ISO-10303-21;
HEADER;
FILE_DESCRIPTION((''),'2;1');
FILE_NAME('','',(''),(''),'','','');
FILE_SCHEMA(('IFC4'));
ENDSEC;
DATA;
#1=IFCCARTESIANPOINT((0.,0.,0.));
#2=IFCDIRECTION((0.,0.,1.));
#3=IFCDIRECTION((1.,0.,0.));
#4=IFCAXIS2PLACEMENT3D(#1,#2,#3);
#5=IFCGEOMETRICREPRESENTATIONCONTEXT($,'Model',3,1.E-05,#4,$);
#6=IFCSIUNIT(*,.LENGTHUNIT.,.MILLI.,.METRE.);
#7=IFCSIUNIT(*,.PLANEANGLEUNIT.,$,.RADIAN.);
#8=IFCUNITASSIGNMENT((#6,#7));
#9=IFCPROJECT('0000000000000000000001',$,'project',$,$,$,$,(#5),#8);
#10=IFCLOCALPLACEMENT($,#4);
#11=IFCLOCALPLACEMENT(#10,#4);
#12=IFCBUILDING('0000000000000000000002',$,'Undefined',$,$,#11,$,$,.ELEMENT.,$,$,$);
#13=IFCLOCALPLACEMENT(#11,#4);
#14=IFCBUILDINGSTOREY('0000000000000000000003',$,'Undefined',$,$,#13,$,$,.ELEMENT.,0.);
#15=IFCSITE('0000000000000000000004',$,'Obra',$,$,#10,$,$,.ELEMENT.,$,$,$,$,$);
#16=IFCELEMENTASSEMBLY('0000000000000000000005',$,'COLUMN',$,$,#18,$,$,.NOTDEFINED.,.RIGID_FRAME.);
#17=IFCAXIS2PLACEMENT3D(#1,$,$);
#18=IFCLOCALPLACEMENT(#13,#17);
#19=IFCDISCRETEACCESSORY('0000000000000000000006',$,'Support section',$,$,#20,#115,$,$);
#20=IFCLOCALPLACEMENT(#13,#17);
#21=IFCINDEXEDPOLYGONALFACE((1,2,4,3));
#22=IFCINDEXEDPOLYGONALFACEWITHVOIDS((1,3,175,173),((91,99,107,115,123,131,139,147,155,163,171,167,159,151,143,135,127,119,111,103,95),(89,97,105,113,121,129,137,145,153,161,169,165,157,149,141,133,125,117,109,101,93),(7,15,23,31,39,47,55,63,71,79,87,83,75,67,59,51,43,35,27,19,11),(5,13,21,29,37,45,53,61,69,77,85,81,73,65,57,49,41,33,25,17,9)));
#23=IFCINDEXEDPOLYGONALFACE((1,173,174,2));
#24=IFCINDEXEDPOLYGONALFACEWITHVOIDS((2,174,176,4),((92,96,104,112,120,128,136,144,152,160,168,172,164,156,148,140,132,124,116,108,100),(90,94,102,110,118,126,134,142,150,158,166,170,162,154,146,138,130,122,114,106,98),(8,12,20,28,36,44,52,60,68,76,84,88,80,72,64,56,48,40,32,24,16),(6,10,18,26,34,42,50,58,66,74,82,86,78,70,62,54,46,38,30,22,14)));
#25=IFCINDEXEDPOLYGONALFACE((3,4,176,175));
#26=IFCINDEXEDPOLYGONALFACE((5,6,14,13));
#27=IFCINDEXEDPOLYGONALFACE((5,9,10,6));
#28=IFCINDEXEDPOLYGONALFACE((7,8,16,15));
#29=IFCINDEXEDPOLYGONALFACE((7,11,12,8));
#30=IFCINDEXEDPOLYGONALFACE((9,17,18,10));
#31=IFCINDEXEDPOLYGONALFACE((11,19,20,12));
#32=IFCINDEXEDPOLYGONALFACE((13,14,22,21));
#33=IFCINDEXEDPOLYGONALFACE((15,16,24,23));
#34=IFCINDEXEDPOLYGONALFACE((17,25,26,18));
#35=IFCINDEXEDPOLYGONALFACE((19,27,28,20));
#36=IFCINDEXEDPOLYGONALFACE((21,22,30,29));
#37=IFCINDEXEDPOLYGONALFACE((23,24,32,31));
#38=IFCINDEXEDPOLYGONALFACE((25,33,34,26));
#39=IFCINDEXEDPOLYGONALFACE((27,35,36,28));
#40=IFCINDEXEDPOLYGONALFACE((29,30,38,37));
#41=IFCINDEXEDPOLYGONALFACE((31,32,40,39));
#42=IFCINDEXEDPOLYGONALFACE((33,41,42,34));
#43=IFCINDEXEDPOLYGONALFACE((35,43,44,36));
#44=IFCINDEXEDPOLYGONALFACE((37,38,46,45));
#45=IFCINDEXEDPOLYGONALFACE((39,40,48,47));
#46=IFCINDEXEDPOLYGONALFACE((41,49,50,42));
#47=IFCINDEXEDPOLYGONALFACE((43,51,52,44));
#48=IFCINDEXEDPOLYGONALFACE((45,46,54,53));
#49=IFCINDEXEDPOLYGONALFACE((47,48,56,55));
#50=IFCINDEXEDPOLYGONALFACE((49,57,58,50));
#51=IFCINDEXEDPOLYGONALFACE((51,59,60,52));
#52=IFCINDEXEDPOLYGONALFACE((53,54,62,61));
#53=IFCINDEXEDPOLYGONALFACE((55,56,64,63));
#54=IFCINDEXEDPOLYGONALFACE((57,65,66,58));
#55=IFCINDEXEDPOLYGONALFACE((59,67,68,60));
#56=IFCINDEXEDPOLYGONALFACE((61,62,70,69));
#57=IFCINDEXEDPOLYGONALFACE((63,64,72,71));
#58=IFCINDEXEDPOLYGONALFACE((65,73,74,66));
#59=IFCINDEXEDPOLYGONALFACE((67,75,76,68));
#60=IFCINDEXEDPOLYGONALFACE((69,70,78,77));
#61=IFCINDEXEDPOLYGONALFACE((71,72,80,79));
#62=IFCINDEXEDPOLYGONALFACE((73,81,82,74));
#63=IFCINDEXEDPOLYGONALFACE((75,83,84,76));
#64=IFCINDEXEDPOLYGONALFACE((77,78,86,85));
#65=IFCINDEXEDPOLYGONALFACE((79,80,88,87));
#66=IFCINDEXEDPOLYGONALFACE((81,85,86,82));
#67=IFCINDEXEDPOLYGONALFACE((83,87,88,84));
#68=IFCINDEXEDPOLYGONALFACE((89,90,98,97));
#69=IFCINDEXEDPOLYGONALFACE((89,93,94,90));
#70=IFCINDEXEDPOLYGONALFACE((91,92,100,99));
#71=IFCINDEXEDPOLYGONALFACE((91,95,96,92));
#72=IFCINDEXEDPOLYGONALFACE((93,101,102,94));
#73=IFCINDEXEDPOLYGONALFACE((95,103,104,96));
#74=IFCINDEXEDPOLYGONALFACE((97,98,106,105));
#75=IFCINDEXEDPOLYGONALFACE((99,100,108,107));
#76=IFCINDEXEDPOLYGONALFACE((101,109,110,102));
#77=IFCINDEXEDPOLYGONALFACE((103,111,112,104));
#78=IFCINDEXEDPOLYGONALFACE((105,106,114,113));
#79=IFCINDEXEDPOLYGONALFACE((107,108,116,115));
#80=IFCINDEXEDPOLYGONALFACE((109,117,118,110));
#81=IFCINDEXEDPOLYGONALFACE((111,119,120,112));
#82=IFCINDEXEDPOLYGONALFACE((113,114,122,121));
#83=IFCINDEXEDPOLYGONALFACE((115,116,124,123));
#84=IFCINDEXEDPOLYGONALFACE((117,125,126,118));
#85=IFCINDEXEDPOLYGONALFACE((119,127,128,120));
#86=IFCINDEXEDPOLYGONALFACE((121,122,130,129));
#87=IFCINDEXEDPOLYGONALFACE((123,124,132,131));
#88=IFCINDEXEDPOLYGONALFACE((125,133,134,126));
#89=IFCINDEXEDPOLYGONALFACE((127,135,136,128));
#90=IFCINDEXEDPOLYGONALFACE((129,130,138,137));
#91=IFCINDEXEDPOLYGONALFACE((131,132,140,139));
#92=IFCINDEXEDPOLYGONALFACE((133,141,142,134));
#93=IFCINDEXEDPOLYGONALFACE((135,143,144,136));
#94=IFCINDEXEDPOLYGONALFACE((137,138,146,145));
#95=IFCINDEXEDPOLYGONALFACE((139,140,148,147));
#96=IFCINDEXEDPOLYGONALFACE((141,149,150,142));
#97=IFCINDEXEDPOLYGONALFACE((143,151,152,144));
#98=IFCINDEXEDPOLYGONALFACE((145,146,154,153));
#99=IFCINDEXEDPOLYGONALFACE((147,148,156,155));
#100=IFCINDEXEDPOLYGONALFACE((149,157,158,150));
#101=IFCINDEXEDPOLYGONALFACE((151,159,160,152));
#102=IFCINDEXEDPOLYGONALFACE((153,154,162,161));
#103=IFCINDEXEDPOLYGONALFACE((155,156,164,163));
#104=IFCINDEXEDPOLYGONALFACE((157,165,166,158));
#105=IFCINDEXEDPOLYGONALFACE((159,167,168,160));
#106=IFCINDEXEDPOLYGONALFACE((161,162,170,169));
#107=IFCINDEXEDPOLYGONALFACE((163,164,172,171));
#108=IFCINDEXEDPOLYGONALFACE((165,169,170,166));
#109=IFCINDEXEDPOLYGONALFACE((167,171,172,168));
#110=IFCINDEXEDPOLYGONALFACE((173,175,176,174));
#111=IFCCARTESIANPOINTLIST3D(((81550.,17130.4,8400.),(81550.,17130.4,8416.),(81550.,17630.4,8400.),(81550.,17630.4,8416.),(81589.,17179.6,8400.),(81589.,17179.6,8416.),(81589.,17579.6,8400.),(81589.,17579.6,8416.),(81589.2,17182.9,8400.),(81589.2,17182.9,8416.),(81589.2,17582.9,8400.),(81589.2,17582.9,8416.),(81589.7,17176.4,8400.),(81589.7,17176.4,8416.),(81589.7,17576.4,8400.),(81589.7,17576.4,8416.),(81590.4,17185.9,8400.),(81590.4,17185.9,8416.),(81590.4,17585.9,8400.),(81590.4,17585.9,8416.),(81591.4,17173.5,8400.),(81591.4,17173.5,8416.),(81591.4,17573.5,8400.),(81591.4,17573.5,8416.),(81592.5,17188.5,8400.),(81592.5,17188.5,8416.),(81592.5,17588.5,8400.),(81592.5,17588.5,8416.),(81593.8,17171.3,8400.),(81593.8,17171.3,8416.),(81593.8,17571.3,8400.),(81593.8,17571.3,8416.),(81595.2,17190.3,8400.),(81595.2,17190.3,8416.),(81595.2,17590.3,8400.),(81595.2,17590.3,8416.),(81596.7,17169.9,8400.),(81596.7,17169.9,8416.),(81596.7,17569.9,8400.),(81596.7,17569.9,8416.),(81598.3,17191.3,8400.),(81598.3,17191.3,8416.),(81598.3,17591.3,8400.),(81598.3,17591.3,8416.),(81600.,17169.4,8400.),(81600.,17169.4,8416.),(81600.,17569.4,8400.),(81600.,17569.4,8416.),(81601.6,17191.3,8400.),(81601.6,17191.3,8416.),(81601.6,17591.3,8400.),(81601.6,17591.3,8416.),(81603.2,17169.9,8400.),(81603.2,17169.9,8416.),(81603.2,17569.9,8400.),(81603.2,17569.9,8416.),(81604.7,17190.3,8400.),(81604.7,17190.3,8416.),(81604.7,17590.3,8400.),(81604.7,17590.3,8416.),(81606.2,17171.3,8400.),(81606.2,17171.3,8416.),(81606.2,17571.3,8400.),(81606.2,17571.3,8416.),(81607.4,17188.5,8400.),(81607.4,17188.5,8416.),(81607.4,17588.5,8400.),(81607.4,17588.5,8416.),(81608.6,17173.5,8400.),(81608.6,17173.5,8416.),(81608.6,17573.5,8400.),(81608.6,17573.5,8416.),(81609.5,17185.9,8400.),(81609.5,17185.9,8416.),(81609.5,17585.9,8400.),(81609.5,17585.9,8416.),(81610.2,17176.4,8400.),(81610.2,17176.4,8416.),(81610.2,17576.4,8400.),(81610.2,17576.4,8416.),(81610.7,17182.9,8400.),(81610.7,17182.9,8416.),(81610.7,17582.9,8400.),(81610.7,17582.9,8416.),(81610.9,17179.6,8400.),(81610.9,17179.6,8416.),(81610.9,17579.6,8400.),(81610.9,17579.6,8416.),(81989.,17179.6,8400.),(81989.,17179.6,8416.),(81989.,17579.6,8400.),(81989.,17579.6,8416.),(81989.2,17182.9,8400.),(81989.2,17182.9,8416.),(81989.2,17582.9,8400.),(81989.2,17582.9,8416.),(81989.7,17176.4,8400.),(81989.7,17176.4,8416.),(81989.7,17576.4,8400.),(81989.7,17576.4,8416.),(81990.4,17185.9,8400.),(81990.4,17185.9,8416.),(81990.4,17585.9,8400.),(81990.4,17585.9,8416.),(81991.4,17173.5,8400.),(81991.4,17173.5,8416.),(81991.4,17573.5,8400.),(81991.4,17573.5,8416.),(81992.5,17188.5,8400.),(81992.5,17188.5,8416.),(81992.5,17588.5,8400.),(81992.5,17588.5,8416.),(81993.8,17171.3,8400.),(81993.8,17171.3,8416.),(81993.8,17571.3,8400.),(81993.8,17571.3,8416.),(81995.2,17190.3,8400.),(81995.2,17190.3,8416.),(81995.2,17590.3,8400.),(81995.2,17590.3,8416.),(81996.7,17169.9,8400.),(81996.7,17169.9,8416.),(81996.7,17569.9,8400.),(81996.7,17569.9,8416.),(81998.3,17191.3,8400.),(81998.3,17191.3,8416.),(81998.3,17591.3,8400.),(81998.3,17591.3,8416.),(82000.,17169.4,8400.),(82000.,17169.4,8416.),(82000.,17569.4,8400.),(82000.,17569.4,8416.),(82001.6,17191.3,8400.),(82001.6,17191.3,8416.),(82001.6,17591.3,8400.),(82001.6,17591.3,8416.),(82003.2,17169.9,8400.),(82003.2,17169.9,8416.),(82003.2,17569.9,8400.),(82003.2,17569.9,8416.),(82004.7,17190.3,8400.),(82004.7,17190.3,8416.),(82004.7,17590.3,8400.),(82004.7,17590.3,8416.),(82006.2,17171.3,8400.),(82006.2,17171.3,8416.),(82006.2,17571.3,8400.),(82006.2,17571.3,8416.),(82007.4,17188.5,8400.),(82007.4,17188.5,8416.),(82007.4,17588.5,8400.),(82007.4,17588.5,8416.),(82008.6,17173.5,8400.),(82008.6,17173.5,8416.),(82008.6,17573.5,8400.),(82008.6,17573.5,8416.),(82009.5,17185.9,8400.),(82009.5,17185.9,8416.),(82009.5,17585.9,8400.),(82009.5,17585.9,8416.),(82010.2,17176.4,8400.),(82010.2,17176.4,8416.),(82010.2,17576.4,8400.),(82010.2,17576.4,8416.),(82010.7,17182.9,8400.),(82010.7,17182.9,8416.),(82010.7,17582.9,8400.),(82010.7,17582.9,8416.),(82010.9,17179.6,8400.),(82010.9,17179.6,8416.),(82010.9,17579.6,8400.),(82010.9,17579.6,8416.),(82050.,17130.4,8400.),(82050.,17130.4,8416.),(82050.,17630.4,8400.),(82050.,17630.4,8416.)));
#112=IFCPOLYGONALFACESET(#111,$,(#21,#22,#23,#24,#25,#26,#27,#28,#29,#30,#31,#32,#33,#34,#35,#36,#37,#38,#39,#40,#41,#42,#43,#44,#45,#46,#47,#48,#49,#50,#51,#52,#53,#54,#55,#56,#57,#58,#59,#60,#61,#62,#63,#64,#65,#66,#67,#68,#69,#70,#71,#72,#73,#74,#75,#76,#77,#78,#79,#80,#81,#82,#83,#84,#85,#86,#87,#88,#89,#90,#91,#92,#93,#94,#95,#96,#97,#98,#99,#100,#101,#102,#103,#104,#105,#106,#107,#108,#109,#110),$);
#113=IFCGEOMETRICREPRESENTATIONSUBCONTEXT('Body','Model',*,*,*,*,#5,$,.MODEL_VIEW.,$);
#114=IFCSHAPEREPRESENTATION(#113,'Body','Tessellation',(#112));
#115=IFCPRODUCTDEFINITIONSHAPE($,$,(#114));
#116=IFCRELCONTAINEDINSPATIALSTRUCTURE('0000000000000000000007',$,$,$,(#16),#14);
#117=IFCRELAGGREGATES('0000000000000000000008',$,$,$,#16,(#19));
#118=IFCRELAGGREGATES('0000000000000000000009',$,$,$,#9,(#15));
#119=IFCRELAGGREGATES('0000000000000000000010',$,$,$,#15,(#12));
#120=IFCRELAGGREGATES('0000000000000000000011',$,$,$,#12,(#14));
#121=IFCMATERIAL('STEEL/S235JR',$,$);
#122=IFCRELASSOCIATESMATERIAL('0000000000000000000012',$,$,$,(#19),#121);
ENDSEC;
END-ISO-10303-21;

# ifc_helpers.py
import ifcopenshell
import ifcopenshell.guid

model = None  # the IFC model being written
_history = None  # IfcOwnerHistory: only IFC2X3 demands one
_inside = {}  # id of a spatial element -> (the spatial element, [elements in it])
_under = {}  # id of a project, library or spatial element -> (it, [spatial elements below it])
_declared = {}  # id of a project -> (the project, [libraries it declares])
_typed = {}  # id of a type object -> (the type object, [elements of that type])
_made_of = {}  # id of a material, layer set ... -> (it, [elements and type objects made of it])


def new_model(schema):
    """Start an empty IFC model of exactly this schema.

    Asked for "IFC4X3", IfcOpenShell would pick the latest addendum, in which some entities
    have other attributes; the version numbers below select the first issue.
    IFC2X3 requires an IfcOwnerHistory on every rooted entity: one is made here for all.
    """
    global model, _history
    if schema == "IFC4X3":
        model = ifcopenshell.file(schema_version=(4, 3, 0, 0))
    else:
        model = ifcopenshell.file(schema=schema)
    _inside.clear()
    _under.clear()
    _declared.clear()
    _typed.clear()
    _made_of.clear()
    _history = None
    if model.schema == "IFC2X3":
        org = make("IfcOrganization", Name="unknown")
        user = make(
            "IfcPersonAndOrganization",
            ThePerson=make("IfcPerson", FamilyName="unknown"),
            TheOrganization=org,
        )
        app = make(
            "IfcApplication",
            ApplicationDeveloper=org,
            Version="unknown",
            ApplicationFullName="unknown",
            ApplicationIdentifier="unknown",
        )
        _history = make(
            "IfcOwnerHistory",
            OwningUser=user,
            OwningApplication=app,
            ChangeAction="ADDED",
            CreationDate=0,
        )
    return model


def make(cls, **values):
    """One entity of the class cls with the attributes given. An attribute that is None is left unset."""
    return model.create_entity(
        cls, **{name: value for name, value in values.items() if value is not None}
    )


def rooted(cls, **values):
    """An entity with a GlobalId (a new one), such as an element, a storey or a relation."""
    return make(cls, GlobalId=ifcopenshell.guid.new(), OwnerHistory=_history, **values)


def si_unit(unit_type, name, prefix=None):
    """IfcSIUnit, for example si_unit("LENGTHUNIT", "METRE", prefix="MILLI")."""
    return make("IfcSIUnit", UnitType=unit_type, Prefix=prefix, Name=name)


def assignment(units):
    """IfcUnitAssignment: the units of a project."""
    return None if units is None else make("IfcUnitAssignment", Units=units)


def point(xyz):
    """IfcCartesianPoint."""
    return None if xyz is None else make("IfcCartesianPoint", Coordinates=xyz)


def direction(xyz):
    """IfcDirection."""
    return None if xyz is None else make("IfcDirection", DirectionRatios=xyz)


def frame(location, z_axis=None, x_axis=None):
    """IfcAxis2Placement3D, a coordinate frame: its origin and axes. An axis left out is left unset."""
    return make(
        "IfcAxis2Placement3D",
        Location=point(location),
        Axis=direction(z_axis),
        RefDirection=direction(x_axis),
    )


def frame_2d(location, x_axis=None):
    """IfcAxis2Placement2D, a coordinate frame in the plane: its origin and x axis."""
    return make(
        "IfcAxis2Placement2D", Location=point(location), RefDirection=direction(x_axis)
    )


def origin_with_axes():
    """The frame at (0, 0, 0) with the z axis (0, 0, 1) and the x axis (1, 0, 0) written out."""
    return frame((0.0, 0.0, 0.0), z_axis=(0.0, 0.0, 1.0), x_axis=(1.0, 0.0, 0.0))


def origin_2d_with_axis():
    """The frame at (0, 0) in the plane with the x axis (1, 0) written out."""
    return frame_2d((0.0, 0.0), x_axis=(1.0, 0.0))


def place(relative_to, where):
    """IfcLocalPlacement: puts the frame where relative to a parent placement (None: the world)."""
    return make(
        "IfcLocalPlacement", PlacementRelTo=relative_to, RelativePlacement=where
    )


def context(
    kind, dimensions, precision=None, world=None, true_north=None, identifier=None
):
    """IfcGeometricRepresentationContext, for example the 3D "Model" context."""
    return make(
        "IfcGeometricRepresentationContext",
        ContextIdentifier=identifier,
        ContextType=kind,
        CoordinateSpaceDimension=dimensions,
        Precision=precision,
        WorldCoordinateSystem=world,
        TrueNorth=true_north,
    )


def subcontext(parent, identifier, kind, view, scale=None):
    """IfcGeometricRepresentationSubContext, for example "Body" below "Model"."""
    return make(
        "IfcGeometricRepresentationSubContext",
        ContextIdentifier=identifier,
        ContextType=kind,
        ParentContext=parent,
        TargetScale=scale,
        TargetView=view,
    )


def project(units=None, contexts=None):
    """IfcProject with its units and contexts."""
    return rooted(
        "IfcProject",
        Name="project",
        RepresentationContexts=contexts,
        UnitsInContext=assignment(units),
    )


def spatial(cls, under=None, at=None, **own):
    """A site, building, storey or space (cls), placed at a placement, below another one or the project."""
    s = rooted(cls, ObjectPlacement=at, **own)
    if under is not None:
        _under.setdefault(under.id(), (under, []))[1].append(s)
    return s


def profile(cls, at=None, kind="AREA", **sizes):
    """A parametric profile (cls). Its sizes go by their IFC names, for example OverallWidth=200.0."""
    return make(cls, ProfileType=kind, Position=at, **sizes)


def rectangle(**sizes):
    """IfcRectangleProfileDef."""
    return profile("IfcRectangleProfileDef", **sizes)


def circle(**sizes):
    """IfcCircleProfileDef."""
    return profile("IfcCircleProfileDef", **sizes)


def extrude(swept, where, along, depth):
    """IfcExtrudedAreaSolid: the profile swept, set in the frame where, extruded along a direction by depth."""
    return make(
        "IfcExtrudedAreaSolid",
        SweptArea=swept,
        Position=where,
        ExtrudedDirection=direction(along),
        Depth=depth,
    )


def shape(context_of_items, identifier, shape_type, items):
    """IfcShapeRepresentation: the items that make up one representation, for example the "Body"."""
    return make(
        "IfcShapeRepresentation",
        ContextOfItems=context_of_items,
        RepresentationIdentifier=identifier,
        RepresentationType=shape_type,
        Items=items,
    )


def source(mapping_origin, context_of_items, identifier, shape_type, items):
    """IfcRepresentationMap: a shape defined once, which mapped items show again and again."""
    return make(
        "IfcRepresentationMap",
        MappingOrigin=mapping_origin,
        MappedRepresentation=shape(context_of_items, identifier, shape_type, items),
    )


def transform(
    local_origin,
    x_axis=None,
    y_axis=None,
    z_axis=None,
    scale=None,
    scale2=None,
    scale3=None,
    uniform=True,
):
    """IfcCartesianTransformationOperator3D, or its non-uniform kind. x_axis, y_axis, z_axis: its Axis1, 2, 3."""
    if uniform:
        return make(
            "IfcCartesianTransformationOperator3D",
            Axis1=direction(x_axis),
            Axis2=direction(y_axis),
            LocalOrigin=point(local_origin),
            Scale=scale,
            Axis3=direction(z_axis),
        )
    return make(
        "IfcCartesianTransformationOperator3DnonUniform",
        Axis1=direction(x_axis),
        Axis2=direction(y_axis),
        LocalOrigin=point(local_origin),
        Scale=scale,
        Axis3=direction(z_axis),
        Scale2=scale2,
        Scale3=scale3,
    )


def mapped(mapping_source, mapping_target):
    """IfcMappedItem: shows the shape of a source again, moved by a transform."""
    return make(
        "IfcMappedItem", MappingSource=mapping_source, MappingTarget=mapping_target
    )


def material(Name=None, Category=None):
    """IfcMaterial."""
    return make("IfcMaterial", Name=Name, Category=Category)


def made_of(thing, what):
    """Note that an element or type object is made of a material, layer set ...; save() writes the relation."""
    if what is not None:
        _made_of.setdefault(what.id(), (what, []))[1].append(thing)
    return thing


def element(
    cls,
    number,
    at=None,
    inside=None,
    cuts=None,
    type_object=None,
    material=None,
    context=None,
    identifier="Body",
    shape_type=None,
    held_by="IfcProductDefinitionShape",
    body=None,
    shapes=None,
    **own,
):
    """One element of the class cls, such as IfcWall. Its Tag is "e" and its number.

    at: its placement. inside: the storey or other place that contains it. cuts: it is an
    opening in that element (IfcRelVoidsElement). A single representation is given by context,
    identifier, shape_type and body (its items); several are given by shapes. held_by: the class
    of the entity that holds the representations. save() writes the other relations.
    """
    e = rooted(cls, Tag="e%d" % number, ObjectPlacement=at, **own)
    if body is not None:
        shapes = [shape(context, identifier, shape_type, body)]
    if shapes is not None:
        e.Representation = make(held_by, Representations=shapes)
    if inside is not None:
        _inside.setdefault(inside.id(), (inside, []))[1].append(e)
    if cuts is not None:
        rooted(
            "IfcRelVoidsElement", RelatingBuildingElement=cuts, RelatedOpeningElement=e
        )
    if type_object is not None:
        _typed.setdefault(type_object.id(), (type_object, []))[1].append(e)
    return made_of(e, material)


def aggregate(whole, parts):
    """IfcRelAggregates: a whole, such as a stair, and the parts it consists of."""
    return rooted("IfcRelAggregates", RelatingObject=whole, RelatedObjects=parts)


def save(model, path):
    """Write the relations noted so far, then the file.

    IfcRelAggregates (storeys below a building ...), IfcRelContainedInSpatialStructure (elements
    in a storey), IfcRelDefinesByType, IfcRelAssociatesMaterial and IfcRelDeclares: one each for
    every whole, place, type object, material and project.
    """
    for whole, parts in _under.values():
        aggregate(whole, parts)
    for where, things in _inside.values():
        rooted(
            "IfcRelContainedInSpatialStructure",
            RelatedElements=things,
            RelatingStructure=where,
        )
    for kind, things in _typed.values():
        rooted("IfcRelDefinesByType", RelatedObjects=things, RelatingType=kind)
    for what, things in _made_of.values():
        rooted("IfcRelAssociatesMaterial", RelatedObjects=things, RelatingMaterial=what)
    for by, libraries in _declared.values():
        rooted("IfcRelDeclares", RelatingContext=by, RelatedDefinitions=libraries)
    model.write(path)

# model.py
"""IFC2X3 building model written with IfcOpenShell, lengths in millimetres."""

from ifc_helpers import new_model, si_unit, frame, origin_with_axes, origin_2d_with_axis, place, context, subcontext, project, spatial, rectangle, circle, extrude, source, transform, mapped, material, element, aggregate, save


model = new_model("IFC2X3")

# Units and contexts
model_context = context("Model", 3, precision=1e-05, world=origin_with_axes())
body_context = subcontext(model_context, "Body", "Model", "MODEL_VIEW")
ifc_project = project(units=[si_unit("LENGTHUNIT", "METRE", prefix="MILLI"), si_unit("PLANEANGLEUNIT", "RADIAN")], contexts=[model_context])

# Site, building, storey
site_placement = place(None, origin_with_axes())
site = spatial("IfcSite", under=ifc_project, at=site_placement, Name="Obra", CompositionType="ELEMENT")
building_placement = place(site_placement, origin_with_axes())
building = spatial("IfcBuilding", under=site, at=building_placement, Name="Undefined", CompositionType="ELEMENT")
storey_placement = place(building_placement, origin_with_axes())
storey = spatial("IfcBuildingStorey", under=building, at=storey_placement, Name="Undefined", CompositionType="ELEMENT", Elevation=0.0)

# Element assembly
assembly_1_placement = place(storey_placement, origin_with_axes())
assembly_1 = element("IfcElementAssembly", 1, at=assembly_1_placement, inside=storey, Name="COLUMN", AssemblyPlace="NOTDEFINED", PredefinedType="RIGID_FRAME")
ifc_material_1 = material(Name="STEEL/S235JR")

# Discrete accessory, opening
discrete_accessory_1_placement = place(assembly_1_placement, frame((81800.0, 17130.4, 8408.0), z_axis=(-1.0, 0.0, 0.0), x_axis=(0.0, 1.0, 0.0)))
discrete_accessory_1 = element("IfcDiscreteAccessory", 2, at=discrete_accessory_1_placement, material=ifc_material_1, Name="Support section", context=body_context, shape_type="SweptSolid", body=[
    extrude(rectangle(XDim=16.0, YDim=500.0, at=origin_2d_with_axis()), frame((500.0, 0.0, 0.0), z_axis=(-1.0, 0.0, 0.0), x_axis=(0.0, -1.0, 0.0)), (0.0, 0.0, 1.0), 500.0),
])
shared_shape_1 = source(origin_with_axes(), body_context, "Body", "SweptSolid", [
    extrude(circle(Radius=11.0, at=origin_2d_with_axis()), frame((0.0, -0.1, 0.0), z_axis=(0.0, 1.0, 0.0), x_axis=(1.0, 0.0, 0.0)), (0.0, 0.0, 1.0), 16.2),
])
opening_1_placement = place(assembly_1_placement, frame((81800.0, 17583.4, 8416.0), z_axis=(1.0, 0.0, 0.0), x_axis=(0.0, -1.0, 0.0)))
element("IfcOpeningElement", 3, at=opening_1_placement, cuts=discrete_accessory_1, ObjectType="Opening", context=body_context, shape_type="MappedRepresentation", body=[
    mapped(shared_shape_1, transform((3.0, 0.0, 200.0))),
    mapped(shared_shape_1, transform((3.0, 0.0, -200.0))),
    mapped(shared_shape_1, transform((403.0, 0.0, 200.0))),
    mapped(shared_shape_1, transform((403.0, 0.0, -200.0))),
])
aggregate(assembly_1, [discrete_accessory_1])

save(model, "model.ifc")
